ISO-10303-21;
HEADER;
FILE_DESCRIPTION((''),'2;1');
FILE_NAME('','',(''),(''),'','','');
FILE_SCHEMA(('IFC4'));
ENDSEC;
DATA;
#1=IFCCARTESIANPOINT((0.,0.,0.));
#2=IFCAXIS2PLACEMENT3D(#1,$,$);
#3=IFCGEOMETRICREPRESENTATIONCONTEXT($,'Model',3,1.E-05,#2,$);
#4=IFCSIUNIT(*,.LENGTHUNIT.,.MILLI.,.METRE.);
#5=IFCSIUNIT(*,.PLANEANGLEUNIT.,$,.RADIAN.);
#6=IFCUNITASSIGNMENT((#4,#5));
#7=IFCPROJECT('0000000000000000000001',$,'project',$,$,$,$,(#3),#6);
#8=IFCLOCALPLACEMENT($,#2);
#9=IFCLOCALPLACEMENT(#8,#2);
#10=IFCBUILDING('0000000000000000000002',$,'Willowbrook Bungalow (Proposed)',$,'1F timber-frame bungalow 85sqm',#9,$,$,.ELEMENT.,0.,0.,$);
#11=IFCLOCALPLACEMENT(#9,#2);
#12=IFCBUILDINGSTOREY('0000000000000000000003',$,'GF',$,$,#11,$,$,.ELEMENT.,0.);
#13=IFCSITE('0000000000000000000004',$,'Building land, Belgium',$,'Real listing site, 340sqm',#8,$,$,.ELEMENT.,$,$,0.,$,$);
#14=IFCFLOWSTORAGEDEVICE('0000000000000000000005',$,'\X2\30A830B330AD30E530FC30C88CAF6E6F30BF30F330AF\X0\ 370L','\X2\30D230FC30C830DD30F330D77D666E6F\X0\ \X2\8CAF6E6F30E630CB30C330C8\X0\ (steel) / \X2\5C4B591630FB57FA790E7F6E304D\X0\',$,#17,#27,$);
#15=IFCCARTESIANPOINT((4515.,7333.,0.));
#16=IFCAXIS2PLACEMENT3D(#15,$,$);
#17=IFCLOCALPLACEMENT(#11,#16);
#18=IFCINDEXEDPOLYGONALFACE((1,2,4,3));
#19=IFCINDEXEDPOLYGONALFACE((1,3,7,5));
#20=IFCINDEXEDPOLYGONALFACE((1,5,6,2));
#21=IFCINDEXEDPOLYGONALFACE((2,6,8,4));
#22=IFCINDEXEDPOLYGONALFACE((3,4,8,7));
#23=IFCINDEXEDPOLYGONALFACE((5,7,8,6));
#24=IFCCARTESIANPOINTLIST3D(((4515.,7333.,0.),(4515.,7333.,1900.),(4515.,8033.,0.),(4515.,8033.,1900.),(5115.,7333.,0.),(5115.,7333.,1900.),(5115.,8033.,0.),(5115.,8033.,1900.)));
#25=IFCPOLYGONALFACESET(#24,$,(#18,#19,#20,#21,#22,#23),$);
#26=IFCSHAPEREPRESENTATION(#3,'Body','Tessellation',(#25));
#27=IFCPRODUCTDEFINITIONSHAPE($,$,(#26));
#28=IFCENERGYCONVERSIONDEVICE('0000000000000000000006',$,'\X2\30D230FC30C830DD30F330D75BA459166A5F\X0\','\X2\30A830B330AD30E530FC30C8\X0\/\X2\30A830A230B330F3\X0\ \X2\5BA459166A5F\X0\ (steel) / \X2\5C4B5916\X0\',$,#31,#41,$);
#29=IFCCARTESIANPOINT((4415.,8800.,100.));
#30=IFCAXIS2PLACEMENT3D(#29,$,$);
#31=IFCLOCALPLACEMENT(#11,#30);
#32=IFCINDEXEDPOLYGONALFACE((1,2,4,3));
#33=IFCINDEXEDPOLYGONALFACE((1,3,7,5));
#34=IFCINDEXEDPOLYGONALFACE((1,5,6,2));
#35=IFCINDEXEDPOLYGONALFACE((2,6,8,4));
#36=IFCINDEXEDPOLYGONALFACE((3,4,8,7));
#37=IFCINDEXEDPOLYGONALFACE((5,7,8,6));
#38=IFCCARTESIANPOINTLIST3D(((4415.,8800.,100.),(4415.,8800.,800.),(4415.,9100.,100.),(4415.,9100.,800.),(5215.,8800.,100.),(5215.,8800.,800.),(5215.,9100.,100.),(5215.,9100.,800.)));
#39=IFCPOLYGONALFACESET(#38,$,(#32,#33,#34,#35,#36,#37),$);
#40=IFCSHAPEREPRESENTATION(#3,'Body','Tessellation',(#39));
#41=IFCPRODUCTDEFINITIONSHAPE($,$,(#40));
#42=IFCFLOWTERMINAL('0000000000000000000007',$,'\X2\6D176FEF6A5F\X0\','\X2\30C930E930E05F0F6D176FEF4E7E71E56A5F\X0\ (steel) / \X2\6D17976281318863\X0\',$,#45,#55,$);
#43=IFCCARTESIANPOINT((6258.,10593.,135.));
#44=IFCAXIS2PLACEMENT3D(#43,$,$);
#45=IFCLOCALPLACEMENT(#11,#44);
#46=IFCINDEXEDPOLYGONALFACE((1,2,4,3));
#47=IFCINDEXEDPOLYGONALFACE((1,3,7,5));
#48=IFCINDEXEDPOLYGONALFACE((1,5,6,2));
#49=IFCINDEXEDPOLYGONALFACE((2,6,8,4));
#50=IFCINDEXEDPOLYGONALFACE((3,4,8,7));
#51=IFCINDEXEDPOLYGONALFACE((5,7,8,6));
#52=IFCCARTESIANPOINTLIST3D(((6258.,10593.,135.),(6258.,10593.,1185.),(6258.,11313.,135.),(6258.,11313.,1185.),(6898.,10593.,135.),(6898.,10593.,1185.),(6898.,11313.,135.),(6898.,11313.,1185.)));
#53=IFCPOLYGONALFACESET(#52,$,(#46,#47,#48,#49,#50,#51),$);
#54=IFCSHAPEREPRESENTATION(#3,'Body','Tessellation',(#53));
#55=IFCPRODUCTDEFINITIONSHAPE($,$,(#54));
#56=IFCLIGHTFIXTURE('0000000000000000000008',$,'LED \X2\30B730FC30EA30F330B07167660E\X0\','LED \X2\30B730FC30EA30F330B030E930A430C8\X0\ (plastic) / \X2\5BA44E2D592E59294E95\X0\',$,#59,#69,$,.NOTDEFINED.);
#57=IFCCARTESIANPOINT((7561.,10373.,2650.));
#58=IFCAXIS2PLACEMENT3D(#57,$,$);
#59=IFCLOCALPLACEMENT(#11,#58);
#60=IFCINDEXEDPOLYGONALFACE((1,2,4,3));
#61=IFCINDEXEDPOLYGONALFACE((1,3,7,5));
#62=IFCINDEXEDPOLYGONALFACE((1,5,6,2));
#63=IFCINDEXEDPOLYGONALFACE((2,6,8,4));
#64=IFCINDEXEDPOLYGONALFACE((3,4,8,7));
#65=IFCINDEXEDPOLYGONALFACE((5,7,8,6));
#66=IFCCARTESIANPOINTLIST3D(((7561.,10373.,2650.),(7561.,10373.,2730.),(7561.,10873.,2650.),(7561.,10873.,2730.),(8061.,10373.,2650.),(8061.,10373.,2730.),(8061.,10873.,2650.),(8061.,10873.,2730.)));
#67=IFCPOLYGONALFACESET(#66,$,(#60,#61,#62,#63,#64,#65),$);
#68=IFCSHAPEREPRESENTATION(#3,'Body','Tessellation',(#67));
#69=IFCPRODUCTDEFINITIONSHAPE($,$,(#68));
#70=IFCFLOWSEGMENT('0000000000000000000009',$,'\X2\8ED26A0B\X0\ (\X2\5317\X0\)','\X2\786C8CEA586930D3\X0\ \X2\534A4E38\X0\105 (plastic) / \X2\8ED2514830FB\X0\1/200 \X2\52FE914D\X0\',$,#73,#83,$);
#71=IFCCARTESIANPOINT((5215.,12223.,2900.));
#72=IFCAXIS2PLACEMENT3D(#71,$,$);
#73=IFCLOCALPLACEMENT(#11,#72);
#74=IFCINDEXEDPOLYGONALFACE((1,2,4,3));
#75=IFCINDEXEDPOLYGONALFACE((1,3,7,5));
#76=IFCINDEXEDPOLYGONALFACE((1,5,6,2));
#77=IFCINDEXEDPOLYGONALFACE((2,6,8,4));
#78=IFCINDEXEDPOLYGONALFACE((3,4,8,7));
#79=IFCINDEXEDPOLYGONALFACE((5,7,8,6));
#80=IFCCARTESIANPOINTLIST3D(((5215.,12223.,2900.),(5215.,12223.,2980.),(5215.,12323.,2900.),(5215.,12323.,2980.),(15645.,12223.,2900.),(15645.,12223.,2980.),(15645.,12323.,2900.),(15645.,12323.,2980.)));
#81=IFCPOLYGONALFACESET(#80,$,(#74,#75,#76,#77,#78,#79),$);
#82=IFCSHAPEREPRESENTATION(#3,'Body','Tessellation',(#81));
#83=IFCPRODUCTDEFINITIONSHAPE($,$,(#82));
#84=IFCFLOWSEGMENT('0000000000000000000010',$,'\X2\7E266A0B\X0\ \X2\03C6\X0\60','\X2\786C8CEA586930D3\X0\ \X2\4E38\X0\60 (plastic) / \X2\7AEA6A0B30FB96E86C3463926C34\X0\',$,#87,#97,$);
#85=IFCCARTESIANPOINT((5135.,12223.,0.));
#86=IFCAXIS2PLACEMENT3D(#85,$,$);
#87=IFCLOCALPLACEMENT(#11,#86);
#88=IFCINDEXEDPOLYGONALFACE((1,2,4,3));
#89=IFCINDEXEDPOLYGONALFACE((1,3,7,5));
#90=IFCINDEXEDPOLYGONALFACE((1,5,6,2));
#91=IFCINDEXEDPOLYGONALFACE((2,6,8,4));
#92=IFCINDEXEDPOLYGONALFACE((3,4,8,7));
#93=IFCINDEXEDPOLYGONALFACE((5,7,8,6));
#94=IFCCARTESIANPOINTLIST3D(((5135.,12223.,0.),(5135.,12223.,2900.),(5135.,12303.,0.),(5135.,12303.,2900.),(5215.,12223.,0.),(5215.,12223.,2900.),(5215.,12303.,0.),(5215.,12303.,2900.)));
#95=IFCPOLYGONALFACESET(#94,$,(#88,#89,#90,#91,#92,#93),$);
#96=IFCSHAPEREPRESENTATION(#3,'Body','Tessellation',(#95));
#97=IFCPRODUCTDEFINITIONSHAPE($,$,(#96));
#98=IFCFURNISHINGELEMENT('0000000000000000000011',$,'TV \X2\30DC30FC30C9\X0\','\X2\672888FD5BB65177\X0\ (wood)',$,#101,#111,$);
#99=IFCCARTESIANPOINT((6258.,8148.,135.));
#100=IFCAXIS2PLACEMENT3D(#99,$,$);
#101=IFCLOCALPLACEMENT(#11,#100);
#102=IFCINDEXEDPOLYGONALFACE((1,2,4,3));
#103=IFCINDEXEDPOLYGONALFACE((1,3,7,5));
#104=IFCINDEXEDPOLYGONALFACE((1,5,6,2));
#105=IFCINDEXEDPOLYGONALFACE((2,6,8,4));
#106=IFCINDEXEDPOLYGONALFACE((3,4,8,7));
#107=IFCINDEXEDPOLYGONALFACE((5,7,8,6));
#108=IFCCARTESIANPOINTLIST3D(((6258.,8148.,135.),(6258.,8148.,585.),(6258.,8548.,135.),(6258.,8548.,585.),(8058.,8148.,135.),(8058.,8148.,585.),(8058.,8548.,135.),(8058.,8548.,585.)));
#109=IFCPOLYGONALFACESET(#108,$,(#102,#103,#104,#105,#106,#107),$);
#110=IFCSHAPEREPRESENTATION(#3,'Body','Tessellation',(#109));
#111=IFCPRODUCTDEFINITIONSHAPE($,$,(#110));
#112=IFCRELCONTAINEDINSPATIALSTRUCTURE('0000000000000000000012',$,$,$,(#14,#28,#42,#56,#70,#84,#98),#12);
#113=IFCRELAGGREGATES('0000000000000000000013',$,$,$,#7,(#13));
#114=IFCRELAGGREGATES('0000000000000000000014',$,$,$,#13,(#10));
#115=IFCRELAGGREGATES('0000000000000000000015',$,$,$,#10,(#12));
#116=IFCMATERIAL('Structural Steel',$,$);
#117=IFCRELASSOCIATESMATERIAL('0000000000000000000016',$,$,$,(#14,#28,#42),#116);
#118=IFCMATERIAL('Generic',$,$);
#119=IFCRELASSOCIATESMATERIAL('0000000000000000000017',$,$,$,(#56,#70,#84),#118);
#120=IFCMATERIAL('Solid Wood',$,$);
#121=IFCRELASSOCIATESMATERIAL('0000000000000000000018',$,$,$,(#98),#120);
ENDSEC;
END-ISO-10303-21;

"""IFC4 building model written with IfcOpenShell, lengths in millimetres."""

from ifc_helpers import new_model, si_unit, frame, frame_2d, origin, place, context, project, spatial, rectangle, extrude, material, element, save


model = new_model("IFC4")

# Units and contexts
model_context = context("Model", 3, precision=1e-05, world=origin())
ifc_project = project(units=[si_unit("LENGTHUNIT", "METRE", prefix="MILLI"), si_unit("PLANEANGLEUNIT", "RADIAN")], contexts=[model_context])

# Site, building, storey
site_placement = place(None, origin())
site = spatial("IfcSite", under=ifc_project, at=site_placement, Name="Building land, Belgium", ObjectType="Real listing site, 340sqm", CompositionType="ELEMENT", RefElevation=0.0)
building_placement = place(site_placement, origin())
building = spatial("IfcBuilding", under=site, at=building_placement, Name="Willowbrook Bungalow (Proposed)", ObjectType="1F timber-frame bungalow 85sqm", CompositionType="ELEMENT", ElevationOfRefHeight=0.0, ElevationOfTerrain=0.0)
storey_placement = place(building_placement, origin())
storey = spatial("IfcBuildingStorey", under=building, at=storey_placement, Name="GF", CompositionType="ELEMENT", Elevation=0.0)

# Shared definitions
ifc_material_1 = material(Name="Solid Wood")

# Shared definitions
ifc_material_2 = material(Name="Structural Steel")

# Shared definitions
ifc_material_3 = material(Name="Generic")

# Flow storage device
flow_storage_device_placement = place(storey_placement, frame((4515.0, 7333.0, 0.0)))
element("IfcFlowStorageDevice", 1, at=flow_storage_device_placement, inside=storey, material=ifc_material_2, Name="エコキュート貯湯タンク 370L", Description="ヒートポンプ給湯 貯湯ユニット (steel) / 屋外・基礎置き", context=model_context, shape_type="SweptSolid", body=[
    extrude(rectangle(XDim=600.0, YDim=700.0, at=frame_2d((300.0, 350.0))), frame((4515.0, 7333.0, 0.0)), (0.0, 0.0, 1.0), 1900.0),
])

# Energy conversion device
energy_conversion_device_placement = place(storey_placement, frame((4415.0, 8800.0, 100.0)))
element("IfcEnergyConversionDevice", 2, at=energy_conversion_device_placement, inside=storey, material=ifc_material_2, Name="ヒートポンプ室外機", Description="エコキュート/エアコン 室外機 (steel) / 屋外", context=model_context, shape_type="SweptSolid", body=[
    extrude(rectangle(XDim=800.0, YDim=300.0, at=frame_2d((400.0, 150.0))), frame((4415.0, 8800.0, 100.0)), (0.0, 0.0, 1.0), 700.0),
])

# Flow terminal
flow_terminal_placement = place(storey_placement, frame((6258.0, 10593.0, 135.0)))
element("IfcFlowTerminal", 3, at=flow_terminal_placement, inside=storey, material=ifc_material_2, Name="洗濯機", Description="ドラム式洗濯乾燥機 (steel) / 洗面脱衣", context=model_context, shape_type="SweptSolid", body=[
    extrude(rectangle(XDim=640.0, YDim=720.0, at=frame_2d((320.0, 360.0))), frame((6258.0, 10593.0, 135.0)), (0.0, 0.0, 1.0), 1050.0),
])

# Light fixture
light_fixture_placement = place(storey_placement, frame((7561.0, 10373.0, 2650.0)))
element("IfcLightFixture", 4, at=light_fixture_placement, inside=storey, material=ifc_material_3, Name="LED シーリング照明", Description="LED シーリングライト (plastic) / 室中央天井", PredefinedType="NOTDEFINED", context=model_context, shape_type="SweptSolid", body=[
    extrude(rectangle(XDim=500.0, YDim=500.0, at=frame_2d((250.0, 250.0))), frame((7561.0, 10373.0, 2650.0)), (0.0, 0.0, 1.0), 80.0),
])

# Flow segments
flow_segment_1_placement = place(storey_placement, frame((5215.0, 12223.0, 2900.0)))
element("IfcFlowSegment", 5, at=flow_segment_1_placement, inside=storey, material=ifc_material_3, Name="軒樋 (北)", Description="硬質塩ビ 半丸105 (plastic) / 軒先・1/200 勾配", context=model_context, shape_type="SweptSolid", body=[
    extrude(rectangle(XDim=10430.0, YDim=100.0, at=frame_2d((5215.0, 50.0))), frame((5215.0, 12223.0, 2900.0)), (0.0, 0.0, 1.0), 80.0),
])
flow_segment_2_placement = place(storey_placement, frame((5135.0, 12223.0, 0.0)))
element("IfcFlowSegment", 6, at=flow_segment_2_placement, inside=storey, material=ifc_material_3, Name="縦樋 φ60", Description="硬質塩ビ 丸60 (plastic) / 竪樋・雨水排水", context=model_context, shape_type="SweptSolid", body=[
    extrude(rectangle(XDim=80.0, YDim=80.0, at=frame_2d((40.0, 40.0))), frame((5135.0, 12223.0, 0.0)), (0.0, 0.0, 1.0), 2900.0),
])

# Furnishing element
furnishing_placement = place(storey_placement, frame((6258.0, 8148.0, 135.0)))
element("IfcFurnishingElement", 7, at=furnishing_placement, inside=storey, material=ifc_material_1, Name="TV ボード", Description="木製家具 (wood)", context=model_context, shape_type="SweptSolid", body=[
    extrude(rectangle(XDim=1800.0, YDim=400.0, at=frame_2d((900.0, 200.0))), frame((6258.0, 8148.0, 135.0)), (0.0, 0.0, 1.0), 450.0),
])

save(model, "model.ifc")
